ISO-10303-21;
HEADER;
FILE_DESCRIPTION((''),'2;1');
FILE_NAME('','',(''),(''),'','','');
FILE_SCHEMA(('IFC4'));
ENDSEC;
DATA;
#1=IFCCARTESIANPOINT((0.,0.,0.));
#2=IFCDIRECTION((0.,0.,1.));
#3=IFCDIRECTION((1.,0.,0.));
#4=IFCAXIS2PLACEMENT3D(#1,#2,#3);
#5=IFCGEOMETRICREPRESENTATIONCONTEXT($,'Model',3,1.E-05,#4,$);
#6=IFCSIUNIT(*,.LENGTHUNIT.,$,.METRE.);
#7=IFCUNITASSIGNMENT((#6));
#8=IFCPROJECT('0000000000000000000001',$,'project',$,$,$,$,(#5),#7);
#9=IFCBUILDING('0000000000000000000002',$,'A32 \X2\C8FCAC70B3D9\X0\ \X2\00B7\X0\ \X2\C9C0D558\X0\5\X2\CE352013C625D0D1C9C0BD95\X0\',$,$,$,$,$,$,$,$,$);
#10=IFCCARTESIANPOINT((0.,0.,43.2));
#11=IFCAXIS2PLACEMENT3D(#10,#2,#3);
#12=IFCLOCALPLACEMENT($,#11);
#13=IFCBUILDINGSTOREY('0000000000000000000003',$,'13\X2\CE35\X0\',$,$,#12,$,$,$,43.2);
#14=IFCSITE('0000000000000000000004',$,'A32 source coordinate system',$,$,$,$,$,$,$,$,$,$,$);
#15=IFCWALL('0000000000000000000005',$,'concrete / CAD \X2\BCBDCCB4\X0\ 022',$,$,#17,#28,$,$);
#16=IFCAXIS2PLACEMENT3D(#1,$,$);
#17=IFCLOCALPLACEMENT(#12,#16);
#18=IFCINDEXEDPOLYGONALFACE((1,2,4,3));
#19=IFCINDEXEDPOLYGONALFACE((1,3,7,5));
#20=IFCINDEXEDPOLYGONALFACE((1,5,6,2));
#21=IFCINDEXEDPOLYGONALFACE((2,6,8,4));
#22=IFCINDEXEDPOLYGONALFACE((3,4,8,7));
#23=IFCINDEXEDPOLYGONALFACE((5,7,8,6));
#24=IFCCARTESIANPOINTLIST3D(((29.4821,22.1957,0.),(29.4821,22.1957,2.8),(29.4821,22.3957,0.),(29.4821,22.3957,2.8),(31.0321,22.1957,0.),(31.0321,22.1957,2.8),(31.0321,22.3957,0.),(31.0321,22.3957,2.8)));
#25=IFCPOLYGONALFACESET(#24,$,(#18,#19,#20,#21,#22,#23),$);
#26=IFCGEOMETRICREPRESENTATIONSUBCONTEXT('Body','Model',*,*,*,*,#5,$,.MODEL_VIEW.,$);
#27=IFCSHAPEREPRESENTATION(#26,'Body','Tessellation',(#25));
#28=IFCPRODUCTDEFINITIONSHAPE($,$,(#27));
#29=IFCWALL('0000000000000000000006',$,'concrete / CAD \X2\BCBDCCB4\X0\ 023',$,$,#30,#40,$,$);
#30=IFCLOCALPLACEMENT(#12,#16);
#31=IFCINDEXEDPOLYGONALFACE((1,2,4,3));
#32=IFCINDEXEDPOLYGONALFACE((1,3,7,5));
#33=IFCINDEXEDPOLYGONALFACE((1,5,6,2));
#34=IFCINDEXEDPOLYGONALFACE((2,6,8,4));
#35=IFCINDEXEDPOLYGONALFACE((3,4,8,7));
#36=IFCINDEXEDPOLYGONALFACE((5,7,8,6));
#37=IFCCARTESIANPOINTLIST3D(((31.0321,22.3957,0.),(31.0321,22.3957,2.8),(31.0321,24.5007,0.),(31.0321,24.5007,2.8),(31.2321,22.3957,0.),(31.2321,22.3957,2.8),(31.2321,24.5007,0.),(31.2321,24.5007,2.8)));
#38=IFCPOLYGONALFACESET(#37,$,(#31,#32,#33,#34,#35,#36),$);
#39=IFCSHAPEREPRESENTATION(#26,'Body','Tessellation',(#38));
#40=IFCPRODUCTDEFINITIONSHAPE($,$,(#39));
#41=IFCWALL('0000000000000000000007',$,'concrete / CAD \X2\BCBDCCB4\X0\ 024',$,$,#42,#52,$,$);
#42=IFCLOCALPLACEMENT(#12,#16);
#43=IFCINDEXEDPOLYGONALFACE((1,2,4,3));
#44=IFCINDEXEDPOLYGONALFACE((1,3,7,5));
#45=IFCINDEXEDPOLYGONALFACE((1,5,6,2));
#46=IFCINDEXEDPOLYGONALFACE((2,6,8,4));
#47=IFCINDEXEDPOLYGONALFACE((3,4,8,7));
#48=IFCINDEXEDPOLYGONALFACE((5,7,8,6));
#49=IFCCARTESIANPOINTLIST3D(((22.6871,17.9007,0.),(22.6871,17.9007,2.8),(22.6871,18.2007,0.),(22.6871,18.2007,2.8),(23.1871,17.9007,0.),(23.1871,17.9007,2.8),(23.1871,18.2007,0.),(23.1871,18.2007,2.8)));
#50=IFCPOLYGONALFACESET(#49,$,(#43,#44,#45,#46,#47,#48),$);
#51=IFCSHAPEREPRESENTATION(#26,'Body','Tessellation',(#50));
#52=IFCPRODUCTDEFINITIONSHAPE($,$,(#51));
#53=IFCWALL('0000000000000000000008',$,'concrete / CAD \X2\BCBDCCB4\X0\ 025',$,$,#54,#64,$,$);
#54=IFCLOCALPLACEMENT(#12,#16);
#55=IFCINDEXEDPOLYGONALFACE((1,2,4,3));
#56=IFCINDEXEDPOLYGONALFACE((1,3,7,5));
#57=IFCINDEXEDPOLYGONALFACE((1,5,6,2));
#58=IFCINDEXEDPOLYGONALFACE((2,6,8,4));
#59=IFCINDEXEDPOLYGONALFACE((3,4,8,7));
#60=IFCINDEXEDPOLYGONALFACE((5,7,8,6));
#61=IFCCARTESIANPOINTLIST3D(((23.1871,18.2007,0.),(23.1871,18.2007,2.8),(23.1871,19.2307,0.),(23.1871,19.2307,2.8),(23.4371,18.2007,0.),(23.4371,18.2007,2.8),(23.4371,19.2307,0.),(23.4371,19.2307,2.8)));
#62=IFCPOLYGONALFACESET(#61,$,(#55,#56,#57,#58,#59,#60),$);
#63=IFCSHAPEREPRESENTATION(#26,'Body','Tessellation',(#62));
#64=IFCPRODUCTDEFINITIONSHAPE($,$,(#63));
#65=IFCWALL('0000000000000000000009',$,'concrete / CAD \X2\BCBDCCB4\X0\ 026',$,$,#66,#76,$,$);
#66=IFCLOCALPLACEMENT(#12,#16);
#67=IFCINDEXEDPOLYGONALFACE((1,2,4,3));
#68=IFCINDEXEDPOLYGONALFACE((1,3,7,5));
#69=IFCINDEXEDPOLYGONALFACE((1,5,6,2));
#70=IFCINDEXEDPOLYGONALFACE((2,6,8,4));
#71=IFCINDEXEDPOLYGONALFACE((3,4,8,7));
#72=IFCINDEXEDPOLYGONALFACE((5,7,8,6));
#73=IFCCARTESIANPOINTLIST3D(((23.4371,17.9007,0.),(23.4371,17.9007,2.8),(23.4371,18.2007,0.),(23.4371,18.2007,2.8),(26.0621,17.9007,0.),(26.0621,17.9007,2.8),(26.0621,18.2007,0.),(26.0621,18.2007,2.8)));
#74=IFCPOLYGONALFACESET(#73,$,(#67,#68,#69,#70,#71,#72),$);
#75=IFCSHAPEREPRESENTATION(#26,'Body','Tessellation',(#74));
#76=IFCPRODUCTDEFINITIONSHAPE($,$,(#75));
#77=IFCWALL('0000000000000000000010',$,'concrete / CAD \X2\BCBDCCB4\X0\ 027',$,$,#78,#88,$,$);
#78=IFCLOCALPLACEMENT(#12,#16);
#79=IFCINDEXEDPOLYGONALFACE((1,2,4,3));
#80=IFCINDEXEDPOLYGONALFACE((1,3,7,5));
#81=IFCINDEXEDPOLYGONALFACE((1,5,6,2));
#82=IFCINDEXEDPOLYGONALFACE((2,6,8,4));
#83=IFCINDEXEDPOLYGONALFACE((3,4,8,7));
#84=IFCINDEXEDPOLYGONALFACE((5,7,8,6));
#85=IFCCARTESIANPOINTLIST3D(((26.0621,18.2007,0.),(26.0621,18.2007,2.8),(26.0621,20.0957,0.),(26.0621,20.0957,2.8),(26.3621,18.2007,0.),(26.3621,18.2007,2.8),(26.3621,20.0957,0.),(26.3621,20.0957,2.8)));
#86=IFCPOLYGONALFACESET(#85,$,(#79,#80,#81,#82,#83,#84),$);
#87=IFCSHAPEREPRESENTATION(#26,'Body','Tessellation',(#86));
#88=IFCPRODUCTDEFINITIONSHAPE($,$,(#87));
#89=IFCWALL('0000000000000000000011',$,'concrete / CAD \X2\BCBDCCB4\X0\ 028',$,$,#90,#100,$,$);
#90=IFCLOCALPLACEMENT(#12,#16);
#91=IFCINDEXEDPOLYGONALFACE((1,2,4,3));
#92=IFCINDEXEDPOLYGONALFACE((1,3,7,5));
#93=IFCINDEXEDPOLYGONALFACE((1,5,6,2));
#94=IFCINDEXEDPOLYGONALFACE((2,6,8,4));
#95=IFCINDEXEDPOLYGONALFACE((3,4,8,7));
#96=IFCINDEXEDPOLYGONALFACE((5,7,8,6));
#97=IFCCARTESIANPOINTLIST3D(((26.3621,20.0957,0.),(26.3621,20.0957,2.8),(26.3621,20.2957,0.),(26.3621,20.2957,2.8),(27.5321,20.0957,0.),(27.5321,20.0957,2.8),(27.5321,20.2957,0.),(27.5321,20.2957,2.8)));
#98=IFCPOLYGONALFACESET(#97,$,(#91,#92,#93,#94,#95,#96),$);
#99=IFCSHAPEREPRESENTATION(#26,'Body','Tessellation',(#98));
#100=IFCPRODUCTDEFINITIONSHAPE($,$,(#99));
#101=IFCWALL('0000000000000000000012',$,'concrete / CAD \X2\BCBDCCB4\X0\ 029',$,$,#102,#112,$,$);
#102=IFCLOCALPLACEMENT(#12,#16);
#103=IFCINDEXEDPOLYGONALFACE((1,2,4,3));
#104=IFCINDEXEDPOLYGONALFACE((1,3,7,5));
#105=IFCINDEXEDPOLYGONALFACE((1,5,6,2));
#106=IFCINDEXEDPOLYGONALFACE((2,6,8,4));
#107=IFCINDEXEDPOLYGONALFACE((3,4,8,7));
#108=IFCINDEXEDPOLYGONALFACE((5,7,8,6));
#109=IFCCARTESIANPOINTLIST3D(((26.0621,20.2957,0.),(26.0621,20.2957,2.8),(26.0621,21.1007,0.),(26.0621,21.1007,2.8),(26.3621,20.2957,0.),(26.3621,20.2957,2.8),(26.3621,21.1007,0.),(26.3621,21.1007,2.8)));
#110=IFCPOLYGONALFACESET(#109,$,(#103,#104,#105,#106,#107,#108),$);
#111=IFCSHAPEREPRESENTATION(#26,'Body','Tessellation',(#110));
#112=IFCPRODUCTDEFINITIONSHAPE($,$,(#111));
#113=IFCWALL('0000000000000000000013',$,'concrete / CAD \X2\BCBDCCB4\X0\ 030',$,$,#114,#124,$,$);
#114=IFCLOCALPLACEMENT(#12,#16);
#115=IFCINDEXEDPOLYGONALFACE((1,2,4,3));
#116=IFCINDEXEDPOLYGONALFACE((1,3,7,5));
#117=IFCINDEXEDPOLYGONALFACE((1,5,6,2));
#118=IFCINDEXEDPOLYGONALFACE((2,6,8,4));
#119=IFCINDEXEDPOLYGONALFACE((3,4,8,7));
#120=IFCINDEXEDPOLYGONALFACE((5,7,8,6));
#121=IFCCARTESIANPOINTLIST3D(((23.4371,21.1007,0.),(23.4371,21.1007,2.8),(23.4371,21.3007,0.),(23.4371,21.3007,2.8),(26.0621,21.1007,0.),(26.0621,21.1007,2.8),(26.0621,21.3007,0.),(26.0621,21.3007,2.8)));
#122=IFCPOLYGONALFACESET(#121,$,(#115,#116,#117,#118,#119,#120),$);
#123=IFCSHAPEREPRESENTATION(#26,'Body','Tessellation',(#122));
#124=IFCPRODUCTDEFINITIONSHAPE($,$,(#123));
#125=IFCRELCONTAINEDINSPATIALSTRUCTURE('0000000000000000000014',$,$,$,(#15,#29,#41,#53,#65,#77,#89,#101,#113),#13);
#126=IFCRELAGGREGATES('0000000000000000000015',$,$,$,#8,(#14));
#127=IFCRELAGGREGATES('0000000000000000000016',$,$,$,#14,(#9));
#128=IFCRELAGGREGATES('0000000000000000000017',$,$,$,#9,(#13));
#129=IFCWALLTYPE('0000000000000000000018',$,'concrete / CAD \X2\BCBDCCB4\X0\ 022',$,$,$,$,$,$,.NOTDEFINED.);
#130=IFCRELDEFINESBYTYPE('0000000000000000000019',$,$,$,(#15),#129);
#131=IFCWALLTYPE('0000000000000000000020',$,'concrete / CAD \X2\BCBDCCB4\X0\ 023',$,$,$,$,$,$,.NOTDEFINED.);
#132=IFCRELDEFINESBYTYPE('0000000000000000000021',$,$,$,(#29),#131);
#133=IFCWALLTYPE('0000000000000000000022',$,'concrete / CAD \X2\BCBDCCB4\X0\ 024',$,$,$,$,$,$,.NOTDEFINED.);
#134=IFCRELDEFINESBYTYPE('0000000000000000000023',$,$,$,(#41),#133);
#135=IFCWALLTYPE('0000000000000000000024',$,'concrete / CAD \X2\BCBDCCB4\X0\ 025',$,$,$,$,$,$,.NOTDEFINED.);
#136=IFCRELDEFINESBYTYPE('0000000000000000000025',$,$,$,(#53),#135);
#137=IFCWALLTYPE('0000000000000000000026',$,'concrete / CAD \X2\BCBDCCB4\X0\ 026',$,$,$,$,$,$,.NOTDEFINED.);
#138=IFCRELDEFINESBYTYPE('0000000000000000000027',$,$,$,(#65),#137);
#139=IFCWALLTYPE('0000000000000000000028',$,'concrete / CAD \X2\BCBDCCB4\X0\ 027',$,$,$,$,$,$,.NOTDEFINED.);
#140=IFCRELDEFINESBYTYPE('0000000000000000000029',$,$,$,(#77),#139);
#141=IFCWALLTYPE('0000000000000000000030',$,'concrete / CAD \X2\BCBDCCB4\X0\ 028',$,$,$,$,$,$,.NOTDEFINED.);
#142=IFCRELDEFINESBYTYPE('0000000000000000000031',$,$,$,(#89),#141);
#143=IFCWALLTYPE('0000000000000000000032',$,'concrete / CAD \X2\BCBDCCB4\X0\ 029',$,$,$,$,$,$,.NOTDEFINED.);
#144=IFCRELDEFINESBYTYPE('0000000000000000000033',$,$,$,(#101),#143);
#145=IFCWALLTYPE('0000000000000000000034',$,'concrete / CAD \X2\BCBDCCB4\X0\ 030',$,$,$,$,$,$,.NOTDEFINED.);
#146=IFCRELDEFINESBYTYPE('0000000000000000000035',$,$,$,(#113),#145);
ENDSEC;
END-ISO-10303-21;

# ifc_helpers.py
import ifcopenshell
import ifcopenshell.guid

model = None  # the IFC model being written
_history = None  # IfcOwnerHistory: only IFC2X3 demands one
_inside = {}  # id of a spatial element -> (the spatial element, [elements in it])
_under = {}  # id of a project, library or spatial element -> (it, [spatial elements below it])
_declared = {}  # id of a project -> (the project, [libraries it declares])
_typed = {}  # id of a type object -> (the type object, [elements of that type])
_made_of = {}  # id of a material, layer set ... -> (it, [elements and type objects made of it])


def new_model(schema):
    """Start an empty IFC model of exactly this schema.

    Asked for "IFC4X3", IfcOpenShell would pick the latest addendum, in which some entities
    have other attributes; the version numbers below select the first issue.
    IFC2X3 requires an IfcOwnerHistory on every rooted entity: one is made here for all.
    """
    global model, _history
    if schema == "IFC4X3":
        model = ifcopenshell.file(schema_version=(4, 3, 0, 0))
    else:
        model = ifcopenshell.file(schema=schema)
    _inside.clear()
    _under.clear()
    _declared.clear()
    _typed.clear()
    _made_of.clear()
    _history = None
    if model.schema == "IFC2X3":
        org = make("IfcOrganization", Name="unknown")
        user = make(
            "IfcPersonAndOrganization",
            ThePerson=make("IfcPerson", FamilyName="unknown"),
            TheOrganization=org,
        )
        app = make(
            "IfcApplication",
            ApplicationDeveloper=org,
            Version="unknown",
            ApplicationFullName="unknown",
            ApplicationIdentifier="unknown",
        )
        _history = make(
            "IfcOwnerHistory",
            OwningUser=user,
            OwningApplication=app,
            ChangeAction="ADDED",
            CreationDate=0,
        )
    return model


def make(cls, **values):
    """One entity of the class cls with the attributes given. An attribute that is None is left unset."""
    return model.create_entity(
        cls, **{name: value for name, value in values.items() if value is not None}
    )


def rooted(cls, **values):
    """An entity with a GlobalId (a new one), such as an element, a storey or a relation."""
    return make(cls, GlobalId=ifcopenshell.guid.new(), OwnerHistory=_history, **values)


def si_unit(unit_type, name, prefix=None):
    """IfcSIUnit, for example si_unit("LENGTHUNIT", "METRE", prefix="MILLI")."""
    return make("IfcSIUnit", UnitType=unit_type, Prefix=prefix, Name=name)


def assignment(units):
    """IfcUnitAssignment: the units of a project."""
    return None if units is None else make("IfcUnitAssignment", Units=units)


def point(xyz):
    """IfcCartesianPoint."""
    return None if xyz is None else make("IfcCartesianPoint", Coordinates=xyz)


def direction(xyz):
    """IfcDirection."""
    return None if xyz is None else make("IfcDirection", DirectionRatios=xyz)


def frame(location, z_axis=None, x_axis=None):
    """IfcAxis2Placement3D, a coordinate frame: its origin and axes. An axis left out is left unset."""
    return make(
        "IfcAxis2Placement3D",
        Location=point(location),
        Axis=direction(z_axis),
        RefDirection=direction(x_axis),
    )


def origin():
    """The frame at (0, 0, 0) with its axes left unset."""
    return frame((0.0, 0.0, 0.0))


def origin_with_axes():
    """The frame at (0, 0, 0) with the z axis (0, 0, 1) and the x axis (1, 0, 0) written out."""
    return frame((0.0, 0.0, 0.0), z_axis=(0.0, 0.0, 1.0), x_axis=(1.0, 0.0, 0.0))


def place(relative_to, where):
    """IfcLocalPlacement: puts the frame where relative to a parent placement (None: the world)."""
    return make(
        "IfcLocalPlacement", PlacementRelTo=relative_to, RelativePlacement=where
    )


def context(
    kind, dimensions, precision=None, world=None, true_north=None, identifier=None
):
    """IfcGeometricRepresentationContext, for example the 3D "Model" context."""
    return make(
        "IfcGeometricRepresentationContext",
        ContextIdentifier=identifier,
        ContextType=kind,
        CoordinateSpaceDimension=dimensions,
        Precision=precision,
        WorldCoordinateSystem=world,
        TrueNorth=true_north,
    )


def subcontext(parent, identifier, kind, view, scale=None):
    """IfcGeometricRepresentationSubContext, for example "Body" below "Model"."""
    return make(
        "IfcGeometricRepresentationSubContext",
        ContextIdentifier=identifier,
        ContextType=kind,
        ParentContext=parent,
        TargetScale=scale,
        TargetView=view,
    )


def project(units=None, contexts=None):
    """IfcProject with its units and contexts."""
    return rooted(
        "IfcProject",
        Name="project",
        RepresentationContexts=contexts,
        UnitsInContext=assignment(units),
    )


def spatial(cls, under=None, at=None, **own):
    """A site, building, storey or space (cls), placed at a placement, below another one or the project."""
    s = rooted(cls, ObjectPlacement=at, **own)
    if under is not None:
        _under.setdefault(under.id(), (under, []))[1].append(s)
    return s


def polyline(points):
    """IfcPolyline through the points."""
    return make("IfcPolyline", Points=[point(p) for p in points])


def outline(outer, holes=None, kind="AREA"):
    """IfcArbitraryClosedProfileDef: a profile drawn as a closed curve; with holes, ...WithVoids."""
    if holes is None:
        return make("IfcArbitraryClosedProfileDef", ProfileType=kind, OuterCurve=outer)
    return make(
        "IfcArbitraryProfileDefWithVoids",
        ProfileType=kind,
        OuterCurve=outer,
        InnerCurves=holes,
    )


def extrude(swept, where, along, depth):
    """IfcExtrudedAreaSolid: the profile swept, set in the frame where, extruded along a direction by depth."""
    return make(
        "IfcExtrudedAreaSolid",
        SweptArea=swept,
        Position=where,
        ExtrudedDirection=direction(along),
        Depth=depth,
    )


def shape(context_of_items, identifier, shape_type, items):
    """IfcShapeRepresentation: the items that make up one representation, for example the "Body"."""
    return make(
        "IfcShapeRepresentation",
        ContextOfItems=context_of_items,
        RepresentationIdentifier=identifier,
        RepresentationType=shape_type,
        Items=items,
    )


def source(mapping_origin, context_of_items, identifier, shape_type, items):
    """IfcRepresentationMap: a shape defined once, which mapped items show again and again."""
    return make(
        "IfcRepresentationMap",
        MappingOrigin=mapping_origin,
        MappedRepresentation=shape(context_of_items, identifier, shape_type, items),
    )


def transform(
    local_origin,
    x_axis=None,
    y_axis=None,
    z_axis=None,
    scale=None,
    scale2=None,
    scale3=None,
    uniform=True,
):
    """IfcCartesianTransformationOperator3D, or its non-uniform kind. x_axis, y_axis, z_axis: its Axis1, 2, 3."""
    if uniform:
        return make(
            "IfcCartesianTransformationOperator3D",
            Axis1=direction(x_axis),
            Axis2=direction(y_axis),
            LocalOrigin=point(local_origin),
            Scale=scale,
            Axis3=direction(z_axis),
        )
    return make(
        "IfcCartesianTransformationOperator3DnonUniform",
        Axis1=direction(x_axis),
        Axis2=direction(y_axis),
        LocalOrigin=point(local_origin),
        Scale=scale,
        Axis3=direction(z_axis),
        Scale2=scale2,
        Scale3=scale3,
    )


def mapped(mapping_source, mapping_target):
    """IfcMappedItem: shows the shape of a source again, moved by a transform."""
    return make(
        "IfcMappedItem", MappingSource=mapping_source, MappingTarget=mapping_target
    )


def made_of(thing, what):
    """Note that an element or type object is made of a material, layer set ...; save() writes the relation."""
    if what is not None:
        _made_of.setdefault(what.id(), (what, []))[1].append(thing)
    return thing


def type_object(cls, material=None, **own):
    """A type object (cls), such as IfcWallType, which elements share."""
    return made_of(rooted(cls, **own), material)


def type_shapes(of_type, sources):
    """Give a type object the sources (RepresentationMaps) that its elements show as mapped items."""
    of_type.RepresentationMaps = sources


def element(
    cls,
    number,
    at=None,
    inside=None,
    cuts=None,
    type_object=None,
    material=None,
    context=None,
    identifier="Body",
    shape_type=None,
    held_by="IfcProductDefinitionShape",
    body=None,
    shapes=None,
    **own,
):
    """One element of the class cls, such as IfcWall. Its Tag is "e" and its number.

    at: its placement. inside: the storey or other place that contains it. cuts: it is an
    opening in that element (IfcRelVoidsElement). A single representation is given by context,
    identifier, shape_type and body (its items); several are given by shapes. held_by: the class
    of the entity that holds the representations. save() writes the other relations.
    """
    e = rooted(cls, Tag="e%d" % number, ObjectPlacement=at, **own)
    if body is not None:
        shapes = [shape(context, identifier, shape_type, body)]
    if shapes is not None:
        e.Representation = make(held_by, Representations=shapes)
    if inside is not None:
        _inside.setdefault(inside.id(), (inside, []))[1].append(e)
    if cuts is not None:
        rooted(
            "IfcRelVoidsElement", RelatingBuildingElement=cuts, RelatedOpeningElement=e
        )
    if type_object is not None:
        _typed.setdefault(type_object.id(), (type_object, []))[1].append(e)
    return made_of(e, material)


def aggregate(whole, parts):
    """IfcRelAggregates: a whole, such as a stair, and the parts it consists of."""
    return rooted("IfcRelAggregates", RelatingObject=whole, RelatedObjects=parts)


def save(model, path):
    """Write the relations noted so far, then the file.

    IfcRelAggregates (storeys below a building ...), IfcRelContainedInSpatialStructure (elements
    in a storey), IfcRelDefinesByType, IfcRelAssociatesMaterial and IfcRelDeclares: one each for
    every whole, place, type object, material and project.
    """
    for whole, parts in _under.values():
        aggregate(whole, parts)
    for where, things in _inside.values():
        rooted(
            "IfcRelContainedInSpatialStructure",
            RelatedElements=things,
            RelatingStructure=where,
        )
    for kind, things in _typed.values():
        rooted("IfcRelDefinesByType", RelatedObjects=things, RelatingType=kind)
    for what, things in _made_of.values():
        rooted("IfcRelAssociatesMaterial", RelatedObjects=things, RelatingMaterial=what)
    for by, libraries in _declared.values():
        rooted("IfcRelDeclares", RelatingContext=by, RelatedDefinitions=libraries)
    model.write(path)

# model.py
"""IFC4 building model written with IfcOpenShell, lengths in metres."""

from ifc_helpers import new_model, si_unit, frame, origin, origin_with_axes, place, context, subcontext, project, spatial, polyline, outline, extrude, source, transform, mapped, type_object, type_shapes, element, save


model = new_model("IFC4")

# Units and contexts
model_context = context("Model", 3, precision=1e-05, world=origin_with_axes())
body_context = subcontext(model_context, "Body", "Model", "MODEL_VIEW")
ifc_project = project(units=[si_unit("LENGTHUNIT", "METRE")], contexts=[model_context])

# Site, building, storey
site = spatial("IfcSite", under=ifc_project, Name="A32 source coordinate system")
building = spatial("IfcBuilding", under=site, Name="A32 주거동 · 지하5층–옥탑지붕")
storey_placement = place(None, frame((0.0, 0.0, 43.2), z_axis=(0.0, 0.0, 1.0), x_axis=(1.0, 0.0, 0.0)))
storey = spatial("IfcBuildingStorey", under=building, at=storey_placement, Name="13층", Elevation=43.2)

# Walls
wall_type_1 = type_object("IfcWallType", Name="concrete / CAD 벽체 022", PredefinedType="NOTDEFINED")
shared_shape_1 = source(origin(), body_context, "Body", "SweptSolid", [
    extrude(outline(polyline([(31.0321, 22.1957), (29.4821, 22.1957), (29.4821, 22.3957), (31.0321, 22.3957), (31.0321, 22.1957)])), origin(), (0.0, 0.0, 1.0), 2.8),
])
type_shapes(wall_type_1, [shared_shape_1])
wall_1_placement = place(storey_placement, origin_with_axes())
element("IfcWall", 1, at=wall_1_placement, inside=storey, type_object=wall_type_1, Name="concrete / CAD 벽체 022", context=body_context, shape_type="MappedRepresentation", body=[
    mapped(shared_shape_1, transform((0.0, 0.0, 0.0), scale=1.0)),
])
wall_type_2 = type_object("IfcWallType", Name="concrete / CAD 벽체 023", PredefinedType="NOTDEFINED")
shared_shape_2 = source(origin(), body_context, "Body", "SweptSolid", [
    extrude(outline(polyline([(31.2321, 24.5007), (31.2321, 22.3957), (31.0321, 22.3957), (31.0321, 24.5007), (31.2321, 24.5007)])), origin(), (0.0, 0.0, 1.0), 2.8),
])
type_shapes(wall_type_2, [shared_shape_2])
wall_2_placement = place(storey_placement, origin_with_axes())
element("IfcWall", 2, at=wall_2_placement, inside=storey, type_object=wall_type_2, Name="concrete / CAD 벽체 023", context=body_context, shape_type="MappedRepresentation", body=[
    mapped(shared_shape_2, transform((0.0, 0.0, 0.0), scale=1.0)),
])
wall_type_3 = type_object("IfcWallType", Name="concrete / CAD 벽체 024", PredefinedType="NOTDEFINED")
shared_shape_3 = source(origin(), body_context, "Body", "SweptSolid", [
    extrude(outline(polyline([(23.1871, 17.9007), (22.6871, 17.9007), (22.6871, 18.2007), (23.1871, 18.2007), (23.1871, 17.9007)])), origin(), (0.0, 0.0, 1.0), 2.8),
])
type_shapes(wall_type_3, [shared_shape_3])
wall_3_placement = place(storey_placement, origin_with_axes())
element("IfcWall", 3, at=wall_3_placement, inside=storey, type_object=wall_type_3, Name="concrete / CAD 벽체 024", context=body_context, shape_type="MappedRepresentation", body=[
    mapped(shared_shape_3, transform((0.0, 0.0, 0.0), scale=1.0)),
])
wall_type_4 = type_object("IfcWallType", Name="concrete / CAD 벽체 025", PredefinedType="NOTDEFINED")
shared_shape_4 = source(origin(), body_context, "Body", "SweptSolid", [
    extrude(outline(polyline([(23.4371, 19.2307), (23.4371, 18.2007), (23.1871, 18.2007), (23.1871, 19.2307), (23.4371, 19.2307)])), origin(), (0.0, 0.0, 1.0), 2.8),
])
type_shapes(wall_type_4, [shared_shape_4])
wall_4_placement = place(storey_placement, origin_with_axes())
element("IfcWall", 4, at=wall_4_placement, inside=storey, type_object=wall_type_4, Name="concrete / CAD 벽체 025", context=body_context, shape_type="MappedRepresentation", body=[
    mapped(shared_shape_4, transform((0.0, 0.0, 0.0), scale=1.0)),
])
wall_type_5 = type_object("IfcWallType", Name="concrete / CAD 벽체 026", PredefinedType="NOTDEFINED")
shared_shape_5 = source(origin(), body_context, "Body", "SweptSolid", [
    extrude(outline(polyline([(26.0621, 17.9007), (23.4371, 17.9007), (23.4371, 18.2007), (26.0621, 18.2007), (26.0621, 17.9007)])), origin(), (0.0, 0.0, 1.0), 2.8),
])
type_shapes(wall_type_5, [shared_shape_5])
wall_5_placement = place(storey_placement, origin_with_axes())
element("IfcWall", 5, at=wall_5_placement, inside=storey, type_object=wall_type_5, Name="concrete / CAD 벽체 026", context=body_context, shape_type="MappedRepresentation", body=[
    mapped(shared_shape_5, transform((0.0, 0.0, 0.0), scale=1.0)),
])
wall_type_6 = type_object("IfcWallType", Name="concrete / CAD 벽체 027", PredefinedType="NOTDEFINED")
shared_shape_6 = source(origin(), body_context, "Body", "SweptSolid", [
    extrude(outline(polyline([(26.3621, 20.0957), (26.3621, 18.2007), (26.0621, 18.2007), (26.0621, 20.0957), (26.3621, 20.0957)])), origin(), (0.0, 0.0, 1.0), 2.8),
])
type_shapes(wall_type_6, [shared_shape_6])
wall_6_placement = place(storey_placement, origin_with_axes())
element("IfcWall", 6, at=wall_6_placement, inside=storey, type_object=wall_type_6, Name="concrete / CAD 벽체 027", context=body_context, shape_type="MappedRepresentation", body=[
    mapped(shared_shape_6, transform((0.0, 0.0, 0.0), scale=1.0)),
])
wall_type_7 = type_object("IfcWallType", Name="concrete / CAD 벽체 028", PredefinedType="NOTDEFINED")
shared_shape_7 = source(origin(), body_context, "Body", "SweptSolid", [
    extrude(outline(polyline([(27.5321, 20.0957), (26.3621, 20.0957), (26.3621, 20.2957), (27.5321, 20.2957), (27.5321, 20.0957)])), origin(), (0.0, 0.0, 1.0), 2.8),
])
type_shapes(wall_type_7, [shared_shape_7])
wall_7_placement = place(storey_placement, origin_with_axes())
element("IfcWall", 7, at=wall_7_placement, inside=storey, type_object=wall_type_7, Name="concrete / CAD 벽체 028", context=body_context, shape_type="MappedRepresentation", body=[
    mapped(shared_shape_7, transform((0.0, 0.0, 0.0), scale=1.0)),
])
wall_type_8 = type_object("IfcWallType", Name="concrete / CAD 벽체 029", PredefinedType="NOTDEFINED")
shared_shape_8 = source(origin(), body_context, "Body", "SweptSolid", [
    extrude(outline(polyline([(26.3621, 21.1007), (26.3621, 20.2957), (26.0621, 20.2957), (26.0621, 21.1007), (26.3621, 21.1007)])), origin(), (0.0, 0.0, 1.0), 2.8),
])
type_shapes(wall_type_8, [shared_shape_8])
wall_8_placement = place(storey_placement, origin_with_axes())
element("IfcWall", 8, at=wall_8_placement, inside=storey, type_object=wall_type_8, Name="concrete / CAD 벽체 029", context=body_context, shape_type="MappedRepresentation", body=[
    mapped(shared_shape_8, transform((0.0, 0.0, 0.0), scale=1.0)),
])
wall_type_9 = type_object("IfcWallType", Name="concrete / CAD 벽체 030", PredefinedType="NOTDEFINED")
shared_shape_9 = source(origin(), body_context, "Body", "SweptSolid", [
    extrude(outline(polyline([(23.4371, 21.3007), (26.0621, 21.3007), (26.0621, 21.1007), (23.4371, 21.1007), (23.4371, 21.3007)])), origin(), (0.0, 0.0, 1.0), 2.8),
])
type_shapes(wall_type_9, [shared_shape_9])
wall_9_placement = place(storey_placement, origin_with_axes())
element("IfcWall", 9, at=wall_9_placement, inside=storey, type_object=wall_type_9, Name="concrete / CAD 벽체 030", context=body_context, shape_type="MappedRepresentation", body=[
    mapped(shared_shape_9, transform((0.0, 0.0, 0.0), scale=1.0)),
])

save(model, "model.ifc")
